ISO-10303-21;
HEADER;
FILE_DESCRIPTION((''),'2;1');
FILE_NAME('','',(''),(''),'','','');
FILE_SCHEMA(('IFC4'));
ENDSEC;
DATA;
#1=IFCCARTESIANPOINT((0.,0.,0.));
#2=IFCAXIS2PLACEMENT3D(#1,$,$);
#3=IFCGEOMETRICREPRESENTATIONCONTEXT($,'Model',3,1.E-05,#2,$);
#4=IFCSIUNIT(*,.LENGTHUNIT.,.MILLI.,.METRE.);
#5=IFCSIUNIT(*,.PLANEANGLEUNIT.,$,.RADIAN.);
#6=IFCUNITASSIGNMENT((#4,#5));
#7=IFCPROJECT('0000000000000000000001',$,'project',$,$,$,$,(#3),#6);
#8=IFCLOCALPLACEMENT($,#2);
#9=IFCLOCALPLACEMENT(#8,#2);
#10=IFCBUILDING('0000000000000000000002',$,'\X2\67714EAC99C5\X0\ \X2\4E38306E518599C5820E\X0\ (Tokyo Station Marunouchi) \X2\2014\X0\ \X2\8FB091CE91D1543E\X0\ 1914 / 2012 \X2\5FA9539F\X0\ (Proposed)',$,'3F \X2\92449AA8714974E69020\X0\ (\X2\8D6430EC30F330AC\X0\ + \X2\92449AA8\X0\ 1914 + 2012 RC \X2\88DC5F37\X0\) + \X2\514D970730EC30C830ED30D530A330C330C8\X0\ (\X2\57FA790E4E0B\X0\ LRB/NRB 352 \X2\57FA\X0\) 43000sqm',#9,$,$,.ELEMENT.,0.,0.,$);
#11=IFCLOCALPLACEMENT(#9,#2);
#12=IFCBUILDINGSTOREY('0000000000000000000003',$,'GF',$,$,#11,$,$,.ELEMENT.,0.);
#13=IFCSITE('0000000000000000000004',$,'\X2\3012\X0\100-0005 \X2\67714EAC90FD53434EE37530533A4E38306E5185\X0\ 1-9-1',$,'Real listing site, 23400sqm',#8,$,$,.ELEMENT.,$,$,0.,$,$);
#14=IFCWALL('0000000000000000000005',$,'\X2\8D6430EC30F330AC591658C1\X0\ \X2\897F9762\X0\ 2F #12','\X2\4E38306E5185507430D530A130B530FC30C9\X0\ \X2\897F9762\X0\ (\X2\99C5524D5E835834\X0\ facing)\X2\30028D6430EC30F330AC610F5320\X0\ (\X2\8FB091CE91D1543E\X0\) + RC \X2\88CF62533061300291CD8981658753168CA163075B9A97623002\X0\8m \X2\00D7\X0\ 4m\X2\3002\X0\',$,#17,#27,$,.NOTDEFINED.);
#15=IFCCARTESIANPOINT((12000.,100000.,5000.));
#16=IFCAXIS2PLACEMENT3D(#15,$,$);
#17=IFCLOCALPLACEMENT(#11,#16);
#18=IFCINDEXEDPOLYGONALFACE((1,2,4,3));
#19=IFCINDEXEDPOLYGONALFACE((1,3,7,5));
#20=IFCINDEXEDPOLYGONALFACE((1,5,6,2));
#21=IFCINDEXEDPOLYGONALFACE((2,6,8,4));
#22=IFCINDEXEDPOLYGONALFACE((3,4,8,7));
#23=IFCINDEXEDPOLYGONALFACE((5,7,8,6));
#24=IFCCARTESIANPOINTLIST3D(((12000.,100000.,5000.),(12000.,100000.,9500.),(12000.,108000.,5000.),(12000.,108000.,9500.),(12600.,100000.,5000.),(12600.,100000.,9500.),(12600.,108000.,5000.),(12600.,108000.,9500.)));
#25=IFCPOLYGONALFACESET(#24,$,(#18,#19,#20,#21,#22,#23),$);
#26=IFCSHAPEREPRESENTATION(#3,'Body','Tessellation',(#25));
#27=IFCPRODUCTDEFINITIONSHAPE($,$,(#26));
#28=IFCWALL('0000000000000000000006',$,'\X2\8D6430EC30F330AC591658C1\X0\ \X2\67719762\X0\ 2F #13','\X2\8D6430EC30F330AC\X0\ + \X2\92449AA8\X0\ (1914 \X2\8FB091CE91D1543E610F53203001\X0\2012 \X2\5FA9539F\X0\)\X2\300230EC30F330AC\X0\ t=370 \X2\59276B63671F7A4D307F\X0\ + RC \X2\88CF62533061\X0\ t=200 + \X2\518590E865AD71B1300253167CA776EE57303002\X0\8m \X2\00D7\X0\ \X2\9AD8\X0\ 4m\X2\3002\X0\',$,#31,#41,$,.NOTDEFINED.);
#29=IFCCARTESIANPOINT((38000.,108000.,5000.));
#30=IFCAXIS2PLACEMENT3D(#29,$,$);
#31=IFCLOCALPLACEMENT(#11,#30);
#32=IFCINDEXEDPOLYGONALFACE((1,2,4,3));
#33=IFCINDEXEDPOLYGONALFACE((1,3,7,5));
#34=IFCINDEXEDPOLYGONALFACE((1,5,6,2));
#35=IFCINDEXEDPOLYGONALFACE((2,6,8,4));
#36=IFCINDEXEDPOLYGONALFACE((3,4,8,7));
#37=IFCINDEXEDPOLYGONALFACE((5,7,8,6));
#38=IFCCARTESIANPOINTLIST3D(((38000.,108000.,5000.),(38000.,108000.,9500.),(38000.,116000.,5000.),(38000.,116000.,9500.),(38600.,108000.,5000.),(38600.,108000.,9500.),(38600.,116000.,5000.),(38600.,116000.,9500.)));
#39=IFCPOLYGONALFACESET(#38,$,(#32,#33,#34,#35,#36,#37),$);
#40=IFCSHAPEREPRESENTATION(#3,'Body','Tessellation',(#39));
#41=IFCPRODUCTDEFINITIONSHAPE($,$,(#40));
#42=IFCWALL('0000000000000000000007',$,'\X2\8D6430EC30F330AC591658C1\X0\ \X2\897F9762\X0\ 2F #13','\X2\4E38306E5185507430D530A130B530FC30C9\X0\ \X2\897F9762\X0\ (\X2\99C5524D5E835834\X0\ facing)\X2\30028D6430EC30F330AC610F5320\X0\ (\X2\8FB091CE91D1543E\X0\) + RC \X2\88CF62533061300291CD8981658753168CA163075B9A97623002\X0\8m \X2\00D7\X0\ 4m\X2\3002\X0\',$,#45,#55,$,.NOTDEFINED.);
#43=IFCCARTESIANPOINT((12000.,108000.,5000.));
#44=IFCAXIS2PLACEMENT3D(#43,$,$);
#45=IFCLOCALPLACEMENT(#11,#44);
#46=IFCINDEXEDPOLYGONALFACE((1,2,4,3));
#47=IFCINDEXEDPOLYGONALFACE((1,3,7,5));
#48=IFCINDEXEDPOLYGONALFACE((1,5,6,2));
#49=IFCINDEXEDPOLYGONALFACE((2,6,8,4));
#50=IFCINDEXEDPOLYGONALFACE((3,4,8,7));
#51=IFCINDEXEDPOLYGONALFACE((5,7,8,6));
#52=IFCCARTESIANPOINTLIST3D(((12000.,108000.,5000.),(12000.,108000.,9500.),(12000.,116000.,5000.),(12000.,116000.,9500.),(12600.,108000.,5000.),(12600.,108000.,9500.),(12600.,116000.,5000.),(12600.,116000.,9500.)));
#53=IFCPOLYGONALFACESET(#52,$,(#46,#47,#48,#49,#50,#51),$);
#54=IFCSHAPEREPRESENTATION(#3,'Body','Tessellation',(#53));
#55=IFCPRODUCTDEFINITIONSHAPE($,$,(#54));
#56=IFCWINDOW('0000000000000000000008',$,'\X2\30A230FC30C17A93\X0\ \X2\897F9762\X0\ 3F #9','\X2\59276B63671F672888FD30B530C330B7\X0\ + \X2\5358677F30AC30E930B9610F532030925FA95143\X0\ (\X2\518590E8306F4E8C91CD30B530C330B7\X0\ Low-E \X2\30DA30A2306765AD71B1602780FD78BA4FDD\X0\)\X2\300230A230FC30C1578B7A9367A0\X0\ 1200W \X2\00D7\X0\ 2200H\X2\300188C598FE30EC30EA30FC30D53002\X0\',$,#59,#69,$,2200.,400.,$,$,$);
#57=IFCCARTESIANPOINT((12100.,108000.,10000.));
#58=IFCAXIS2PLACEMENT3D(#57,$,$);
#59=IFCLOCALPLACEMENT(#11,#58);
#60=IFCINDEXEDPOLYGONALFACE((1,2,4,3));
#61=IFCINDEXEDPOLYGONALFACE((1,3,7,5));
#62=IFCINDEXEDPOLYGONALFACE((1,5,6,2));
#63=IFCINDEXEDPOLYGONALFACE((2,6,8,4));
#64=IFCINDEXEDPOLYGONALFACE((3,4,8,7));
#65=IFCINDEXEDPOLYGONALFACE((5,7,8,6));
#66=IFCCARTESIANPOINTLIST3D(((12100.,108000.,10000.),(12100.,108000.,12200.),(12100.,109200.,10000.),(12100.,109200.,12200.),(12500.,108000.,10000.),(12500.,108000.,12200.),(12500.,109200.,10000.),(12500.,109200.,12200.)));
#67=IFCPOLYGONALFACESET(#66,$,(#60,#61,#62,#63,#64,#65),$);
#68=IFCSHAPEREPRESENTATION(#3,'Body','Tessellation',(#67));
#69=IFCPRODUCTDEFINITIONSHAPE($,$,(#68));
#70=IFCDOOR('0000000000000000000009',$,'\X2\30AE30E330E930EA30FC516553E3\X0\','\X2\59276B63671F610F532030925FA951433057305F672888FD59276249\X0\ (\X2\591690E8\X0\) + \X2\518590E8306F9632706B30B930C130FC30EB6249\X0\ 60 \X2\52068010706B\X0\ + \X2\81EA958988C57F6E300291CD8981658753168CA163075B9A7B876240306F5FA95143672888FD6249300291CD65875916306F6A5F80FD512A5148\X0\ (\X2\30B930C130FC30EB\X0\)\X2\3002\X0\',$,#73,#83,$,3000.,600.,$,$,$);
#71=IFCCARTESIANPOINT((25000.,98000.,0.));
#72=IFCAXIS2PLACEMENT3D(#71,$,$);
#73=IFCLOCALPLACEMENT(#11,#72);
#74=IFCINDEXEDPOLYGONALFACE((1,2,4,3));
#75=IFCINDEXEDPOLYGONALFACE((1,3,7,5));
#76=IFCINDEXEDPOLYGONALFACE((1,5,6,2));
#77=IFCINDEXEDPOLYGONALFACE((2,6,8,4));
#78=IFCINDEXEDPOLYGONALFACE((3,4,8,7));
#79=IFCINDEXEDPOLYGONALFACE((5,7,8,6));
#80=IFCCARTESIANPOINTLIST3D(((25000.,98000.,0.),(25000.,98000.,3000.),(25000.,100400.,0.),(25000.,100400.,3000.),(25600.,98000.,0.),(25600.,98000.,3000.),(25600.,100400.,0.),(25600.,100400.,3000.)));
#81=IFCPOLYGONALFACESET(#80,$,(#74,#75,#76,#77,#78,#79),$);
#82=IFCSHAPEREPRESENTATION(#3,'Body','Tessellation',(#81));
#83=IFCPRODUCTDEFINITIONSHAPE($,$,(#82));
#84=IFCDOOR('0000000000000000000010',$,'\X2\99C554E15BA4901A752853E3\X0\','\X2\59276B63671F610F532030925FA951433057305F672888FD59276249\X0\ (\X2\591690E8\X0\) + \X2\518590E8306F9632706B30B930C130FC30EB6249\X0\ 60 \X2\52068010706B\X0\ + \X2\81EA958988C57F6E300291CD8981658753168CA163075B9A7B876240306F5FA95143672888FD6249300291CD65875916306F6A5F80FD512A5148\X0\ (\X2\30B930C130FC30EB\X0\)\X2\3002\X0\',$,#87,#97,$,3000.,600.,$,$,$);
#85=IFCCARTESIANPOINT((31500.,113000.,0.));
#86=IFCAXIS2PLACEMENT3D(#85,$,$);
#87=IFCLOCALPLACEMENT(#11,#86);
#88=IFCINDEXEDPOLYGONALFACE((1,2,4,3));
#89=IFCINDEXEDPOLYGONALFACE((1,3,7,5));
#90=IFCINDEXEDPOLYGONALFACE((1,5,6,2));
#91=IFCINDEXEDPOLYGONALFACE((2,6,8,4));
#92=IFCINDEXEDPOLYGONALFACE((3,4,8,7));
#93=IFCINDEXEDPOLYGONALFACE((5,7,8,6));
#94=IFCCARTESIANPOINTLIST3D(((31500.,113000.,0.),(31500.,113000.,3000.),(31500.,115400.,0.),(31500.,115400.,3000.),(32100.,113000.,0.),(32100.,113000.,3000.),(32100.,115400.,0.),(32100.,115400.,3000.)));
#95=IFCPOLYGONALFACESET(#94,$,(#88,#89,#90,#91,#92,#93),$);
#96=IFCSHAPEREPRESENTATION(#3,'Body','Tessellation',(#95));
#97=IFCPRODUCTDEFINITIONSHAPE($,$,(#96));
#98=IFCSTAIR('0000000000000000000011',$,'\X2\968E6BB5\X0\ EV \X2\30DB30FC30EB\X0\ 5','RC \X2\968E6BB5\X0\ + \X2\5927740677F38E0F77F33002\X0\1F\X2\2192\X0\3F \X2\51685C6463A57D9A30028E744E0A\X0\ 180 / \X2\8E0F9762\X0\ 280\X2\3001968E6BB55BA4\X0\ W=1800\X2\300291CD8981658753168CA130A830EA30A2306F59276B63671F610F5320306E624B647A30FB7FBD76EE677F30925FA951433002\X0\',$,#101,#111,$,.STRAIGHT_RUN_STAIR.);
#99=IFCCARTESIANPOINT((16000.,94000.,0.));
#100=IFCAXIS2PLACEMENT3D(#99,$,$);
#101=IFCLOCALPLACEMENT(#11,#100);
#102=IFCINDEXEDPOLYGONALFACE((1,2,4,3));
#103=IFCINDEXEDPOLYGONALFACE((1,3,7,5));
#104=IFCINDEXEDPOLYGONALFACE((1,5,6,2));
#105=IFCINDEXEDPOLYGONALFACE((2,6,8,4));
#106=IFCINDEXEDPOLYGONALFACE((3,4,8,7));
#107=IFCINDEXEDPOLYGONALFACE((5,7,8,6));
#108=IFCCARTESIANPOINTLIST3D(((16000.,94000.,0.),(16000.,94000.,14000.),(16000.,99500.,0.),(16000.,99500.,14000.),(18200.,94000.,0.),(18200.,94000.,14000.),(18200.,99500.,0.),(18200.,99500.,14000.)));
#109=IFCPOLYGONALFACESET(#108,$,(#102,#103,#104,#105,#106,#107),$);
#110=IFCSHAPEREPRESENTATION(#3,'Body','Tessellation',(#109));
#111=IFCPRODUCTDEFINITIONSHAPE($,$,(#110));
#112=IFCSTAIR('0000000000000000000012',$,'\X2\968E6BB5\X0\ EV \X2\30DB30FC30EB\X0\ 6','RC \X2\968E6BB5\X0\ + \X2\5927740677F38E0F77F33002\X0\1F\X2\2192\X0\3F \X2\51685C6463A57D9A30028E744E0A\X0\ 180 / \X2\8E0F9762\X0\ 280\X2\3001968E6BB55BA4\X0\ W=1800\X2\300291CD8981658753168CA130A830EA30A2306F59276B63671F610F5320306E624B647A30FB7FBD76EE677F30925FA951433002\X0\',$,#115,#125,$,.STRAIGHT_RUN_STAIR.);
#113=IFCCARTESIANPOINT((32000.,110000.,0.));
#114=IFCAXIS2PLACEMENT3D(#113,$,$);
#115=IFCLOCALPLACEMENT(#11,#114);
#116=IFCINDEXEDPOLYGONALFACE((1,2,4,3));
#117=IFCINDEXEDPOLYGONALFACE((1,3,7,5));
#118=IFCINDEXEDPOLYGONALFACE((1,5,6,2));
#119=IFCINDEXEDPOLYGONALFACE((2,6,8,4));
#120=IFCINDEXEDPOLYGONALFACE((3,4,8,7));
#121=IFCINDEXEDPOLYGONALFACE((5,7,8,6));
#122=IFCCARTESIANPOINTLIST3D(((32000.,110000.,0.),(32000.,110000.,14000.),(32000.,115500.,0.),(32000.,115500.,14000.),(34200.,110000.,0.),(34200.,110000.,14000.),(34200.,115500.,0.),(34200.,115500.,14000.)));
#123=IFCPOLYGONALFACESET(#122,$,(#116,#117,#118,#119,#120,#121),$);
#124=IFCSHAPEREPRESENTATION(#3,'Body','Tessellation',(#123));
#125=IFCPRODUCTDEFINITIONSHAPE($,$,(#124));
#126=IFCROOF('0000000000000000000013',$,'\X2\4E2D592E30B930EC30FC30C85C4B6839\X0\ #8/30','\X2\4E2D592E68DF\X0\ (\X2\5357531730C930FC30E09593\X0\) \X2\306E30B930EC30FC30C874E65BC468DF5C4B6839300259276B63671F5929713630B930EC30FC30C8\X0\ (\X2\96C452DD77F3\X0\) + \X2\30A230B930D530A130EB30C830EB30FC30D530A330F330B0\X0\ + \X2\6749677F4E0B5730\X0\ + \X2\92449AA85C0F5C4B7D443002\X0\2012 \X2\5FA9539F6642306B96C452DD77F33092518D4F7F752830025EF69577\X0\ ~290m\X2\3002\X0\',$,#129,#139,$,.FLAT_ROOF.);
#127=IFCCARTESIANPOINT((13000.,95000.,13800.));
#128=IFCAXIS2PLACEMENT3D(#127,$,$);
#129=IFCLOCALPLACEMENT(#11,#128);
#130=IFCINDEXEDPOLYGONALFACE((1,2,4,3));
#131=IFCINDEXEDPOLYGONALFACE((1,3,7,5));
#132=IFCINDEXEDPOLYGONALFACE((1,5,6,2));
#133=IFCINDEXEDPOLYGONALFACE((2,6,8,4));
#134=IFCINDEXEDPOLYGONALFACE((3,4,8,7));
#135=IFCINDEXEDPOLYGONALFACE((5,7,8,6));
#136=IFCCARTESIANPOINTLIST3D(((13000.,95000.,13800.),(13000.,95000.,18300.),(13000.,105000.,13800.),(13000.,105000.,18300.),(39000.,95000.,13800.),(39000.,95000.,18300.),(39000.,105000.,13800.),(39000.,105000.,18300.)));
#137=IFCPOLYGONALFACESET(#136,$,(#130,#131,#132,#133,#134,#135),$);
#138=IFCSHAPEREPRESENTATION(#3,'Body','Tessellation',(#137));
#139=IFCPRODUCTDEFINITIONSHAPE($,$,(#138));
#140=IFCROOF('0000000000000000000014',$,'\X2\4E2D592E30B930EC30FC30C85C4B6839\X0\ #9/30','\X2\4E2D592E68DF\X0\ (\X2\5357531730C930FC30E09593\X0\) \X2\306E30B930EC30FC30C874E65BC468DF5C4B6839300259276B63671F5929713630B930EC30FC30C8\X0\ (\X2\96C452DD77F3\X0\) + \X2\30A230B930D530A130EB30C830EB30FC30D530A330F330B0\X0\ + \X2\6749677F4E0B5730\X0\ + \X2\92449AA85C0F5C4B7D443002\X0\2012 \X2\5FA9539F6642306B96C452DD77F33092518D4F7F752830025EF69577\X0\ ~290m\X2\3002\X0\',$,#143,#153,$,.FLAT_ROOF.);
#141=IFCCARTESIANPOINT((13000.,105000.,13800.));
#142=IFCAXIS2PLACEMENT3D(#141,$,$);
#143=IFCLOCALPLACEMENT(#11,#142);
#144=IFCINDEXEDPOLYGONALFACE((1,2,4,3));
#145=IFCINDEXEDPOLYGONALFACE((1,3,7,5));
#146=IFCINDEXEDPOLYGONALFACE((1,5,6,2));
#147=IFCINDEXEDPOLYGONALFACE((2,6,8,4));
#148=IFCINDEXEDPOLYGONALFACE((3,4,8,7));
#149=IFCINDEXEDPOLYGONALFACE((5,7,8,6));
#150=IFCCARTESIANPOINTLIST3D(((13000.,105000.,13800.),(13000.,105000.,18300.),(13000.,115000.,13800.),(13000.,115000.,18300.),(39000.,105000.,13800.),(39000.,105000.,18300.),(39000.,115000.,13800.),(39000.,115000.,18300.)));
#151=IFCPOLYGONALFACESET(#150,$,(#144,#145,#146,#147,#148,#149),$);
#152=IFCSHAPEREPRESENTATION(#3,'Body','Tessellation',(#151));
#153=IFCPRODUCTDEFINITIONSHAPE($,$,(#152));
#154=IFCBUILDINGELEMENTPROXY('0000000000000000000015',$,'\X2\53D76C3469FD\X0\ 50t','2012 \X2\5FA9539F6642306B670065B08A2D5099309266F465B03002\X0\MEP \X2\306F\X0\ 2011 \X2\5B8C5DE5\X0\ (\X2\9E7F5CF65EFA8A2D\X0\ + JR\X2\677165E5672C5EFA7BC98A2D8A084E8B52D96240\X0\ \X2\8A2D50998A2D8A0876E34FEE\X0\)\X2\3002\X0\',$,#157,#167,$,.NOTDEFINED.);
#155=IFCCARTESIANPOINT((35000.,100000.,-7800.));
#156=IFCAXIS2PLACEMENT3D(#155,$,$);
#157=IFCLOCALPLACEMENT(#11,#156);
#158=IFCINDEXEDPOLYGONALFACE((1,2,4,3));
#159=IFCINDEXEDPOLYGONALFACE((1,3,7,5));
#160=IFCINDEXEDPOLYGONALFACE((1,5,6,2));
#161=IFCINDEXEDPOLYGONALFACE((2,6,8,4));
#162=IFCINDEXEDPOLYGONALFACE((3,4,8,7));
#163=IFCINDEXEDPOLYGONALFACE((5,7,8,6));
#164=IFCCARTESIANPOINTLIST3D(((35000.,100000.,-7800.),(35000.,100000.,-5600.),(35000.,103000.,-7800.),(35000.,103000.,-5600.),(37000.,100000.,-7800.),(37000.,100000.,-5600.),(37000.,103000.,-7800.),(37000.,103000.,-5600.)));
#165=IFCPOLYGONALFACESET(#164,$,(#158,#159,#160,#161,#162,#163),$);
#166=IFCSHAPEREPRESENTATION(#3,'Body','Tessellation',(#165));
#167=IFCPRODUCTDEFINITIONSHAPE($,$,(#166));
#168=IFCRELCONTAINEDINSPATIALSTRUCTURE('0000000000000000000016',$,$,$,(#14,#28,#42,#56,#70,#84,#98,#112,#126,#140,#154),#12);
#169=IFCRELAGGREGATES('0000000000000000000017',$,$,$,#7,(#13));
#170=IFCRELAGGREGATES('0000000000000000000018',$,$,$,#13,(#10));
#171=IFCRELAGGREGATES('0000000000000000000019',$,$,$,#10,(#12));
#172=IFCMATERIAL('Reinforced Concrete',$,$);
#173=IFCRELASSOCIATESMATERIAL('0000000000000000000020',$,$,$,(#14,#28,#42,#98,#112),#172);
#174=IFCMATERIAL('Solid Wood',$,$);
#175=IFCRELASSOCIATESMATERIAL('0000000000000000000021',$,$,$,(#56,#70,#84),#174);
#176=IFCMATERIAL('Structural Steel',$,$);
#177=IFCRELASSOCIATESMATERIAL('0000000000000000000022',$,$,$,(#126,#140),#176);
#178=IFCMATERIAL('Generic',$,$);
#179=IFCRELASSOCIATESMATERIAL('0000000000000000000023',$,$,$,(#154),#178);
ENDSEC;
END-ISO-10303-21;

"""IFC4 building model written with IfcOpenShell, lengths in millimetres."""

from ifc_helpers import new_model, si_unit, frame, frame_2d, origin, place, context, project, spatial, rectangle, extrude, material, element, save


model = new_model("IFC4")

# Units and contexts
model_context = context("Model", 3, precision=1e-05, world=origin())
ifc_project = project(units=[si_unit("LENGTHUNIT", "METRE", prefix="MILLI"), si_unit("PLANEANGLEUNIT", "RADIAN")], contexts=[model_context])

# Site, building, storey
site_placement = place(None, origin())
site = spatial("IfcSite", under=ifc_project, at=site_placement, Name="〒100-0005 東京都千代田区丸の内 1-9-1", ObjectType="Real listing site, 23400sqm", CompositionType="ELEMENT", RefElevation=0.0)
building_placement = place(site_placement, origin())
building = spatial("IfcBuilding", under=site, at=building_placement, Name="東京駅 丸の内駅舎 (Tokyo Station Marunouchi) — 辰野金吾 1914 / 2012 復原 (Proposed)", ObjectType="3F 鉄骨煉瓦造 (赤レンガ + 鉄骨 1914 + 2012 RC 補強) + 免震レトロフィット (基礎下 LRB/NRB 352 基) 43000sqm", CompositionType="ELEMENT", ElevationOfRefHeight=0.0, ElevationOfTerrain=0.0)
storey_placement = place(building_placement, origin())
storey = spatial("IfcBuildingStorey", under=building, at=storey_placement, Name="GF", CompositionType="ELEMENT", Elevation=0.0)

# Shared definitions
ifc_material_1 = material(Name="Structural Steel")

# Shared definitions
ifc_material_2 = material(Name="Reinforced Concrete")
ifc_material_3 = material(Name="Generic")

# Shared definitions
ifc_material_4 = material(Name="Solid Wood")

# Walls
wall_1_placement = place(storey_placement, frame((12000.0, 100000.0, 5000.0)))
element("IfcWall", 1, at=wall_1_placement, inside=storey, material=ifc_material_2, Name="赤レンガ外壁 西面 2F #12", Description="丸の内側ファサード 西面 (駅前広場 facing)。赤レンガ意匠 (辰野金吾) + RC 裏打ち。重要文化財指定面。8m × 4m。", PredefinedType="NOTDEFINED", context=model_context, shape_type="SweptSolid", body=[
    extrude(rectangle(XDim=600.0, YDim=8000.0, at=frame_2d((300.0, 4000.0))), frame((12000.0, 100000.0, 5000.0)), (0.0, 0.0, 1.0), 4500.0),
])
wall_2_placement = place(storey_placement, frame((38000.0, 108000.0, 5000.0)))
element("IfcWall", 2, at=wall_2_placement, inside=storey, material=ifc_material_2, Name="赤レンガ外壁 東面 2F #13", Description="赤レンガ + 鉄骨 (1914 辰野金吾意匠、2012 復原)。レンガ t=370 大正期積み + RC 裏打ち t=200 + 内部断熱。化粧目地。8m × 高 4m。", PredefinedType="NOTDEFINED", context=model_context, shape_type="SweptSolid", body=[
    extrude(rectangle(XDim=600.0, YDim=8000.0, at=frame_2d((300.0, 4000.0))), frame((38000.0, 108000.0, 5000.0)), (0.0, 0.0, 1.0), 4500.0),
])
wall_3_placement = place(storey_placement, frame((12000.0, 108000.0, 5000.0)))
element("IfcWall", 3, at=wall_3_placement, inside=storey, material=ifc_material_2, Name="赤レンガ外壁 西面 2F #13", Description="丸の内側ファサード 西面 (駅前広場 facing)。赤レンガ意匠 (辰野金吾) + RC 裏打ち。重要文化財指定面。8m × 4m。", PredefinedType="NOTDEFINED", context=model_context, shape_type="SweptSolid", body=[
    extrude(rectangle(XDim=600.0, YDim=8000.0, at=frame_2d((300.0, 4000.0))), frame((12000.0, 108000.0, 5000.0)), (0.0, 0.0, 1.0), 4500.0),
])

# Window
window_1_placement = place(storey_placement, frame((12100.0, 108000.0, 10000.0)))
element("IfcWindow", 4, at=window_1_placement, inside=storey, material=ifc_material_4, Name="アーチ窓 西面 3F #9", Description="大正期木製サッシ + 単板ガラス意匠を復元 (内部は二重サッシ Low-E ペアで断熱性能確保)。アーチ型窓枠 1200W × 2200H、装飾レリーフ。", OverallHeight=2200.0, OverallWidth=400.0, context=model_context, shape_type="SweptSolid", body=[
    extrude(rectangle(XDim=400.0, YDim=1200.0, at=frame_2d((200.0, 600.0))), frame((12100.0, 108000.0, 10000.0)), (0.0, 0.0, 1.0), 2200.0),
])

# Doors
door_1_placement = place(storey_placement, frame((25000.0, 98000.0, 0.0)))
element("IfcDoor", 5, at=door_1_placement, inside=storey, material=ifc_material_4, Name="ギャラリー入口", Description="大正期意匠を復元した木製大扉 (外部) + 内部は防火スチール扉 60 分耐火 + 自閉装置。重要文化財指定箇所は復元木製扉。重文外は機能優先 (スチール)。", OverallHeight=3000.0, OverallWidth=600.0, context=model_context, shape_type="SweptSolid", body=[
    extrude(rectangle(XDim=600.0, YDim=2400.0, at=frame_2d((300.0, 1200.0))), frame((25000.0, 98000.0, 0.0)), (0.0, 0.0, 1.0), 3000.0),
])
door_2_placement = place(storey_placement, frame((31500.0, 113000.0, 0.0)))
element("IfcDoor", 6, at=door_2_placement, inside=storey, material=ifc_material_4, Name="駅員室通用口", Description="大正期意匠を復元した木製大扉 (外部) + 内部は防火スチール扉 60 分耐火 + 自閉装置。重要文化財指定箇所は復元木製扉。重文外は機能優先 (スチール)。", OverallHeight=3000.0, OverallWidth=600.0, context=model_context, shape_type="SweptSolid", body=[
    extrude(rectangle(XDim=600.0, YDim=2400.0, at=frame_2d((300.0, 1200.0))), frame((31500.0, 113000.0, 0.0)), (0.0, 0.0, 1.0), 3000.0),
])

# Stairs
stair_1_placement = place(storey_placement, frame((16000.0, 94000.0, 0.0)))
element("IfcStair", 7, at=stair_1_placement, inside=storey, material=ifc_material_2, Name="階段 EV ホール 5", Description="RC 階段 + 大理石踏石。1F→3F 全層接続。蹴上 180 / 踏面 280、階段室 W=1800。重要文化財エリアは大正期意匠の手摺・羽目板を復元。", PredefinedType="STRAIGHT_RUN_STAIR", context=model_context, shape_type="SweptSolid", body=[
    extrude(rectangle(XDim=2200.0, YDim=5500.0, at=frame_2d((1100.0, 2750.0))), frame((16000.0, 94000.0, 0.0)), (0.0, 0.0, 1.0), 14000.0),
])
stair_2_placement = place(storey_placement, frame((32000.0, 110000.0, 0.0)))
element("IfcStair", 8, at=stair_2_placement, inside=storey, material=ifc_material_2, Name="階段 EV ホール 6", Description="RC 階段 + 大理石踏石。1F→3F 全層接続。蹴上 180 / 踏面 280、階段室 W=1800。重要文化財エリアは大正期意匠の手摺・羽目板を復元。", PredefinedType="STRAIGHT_RUN_STAIR", context=model_context, shape_type="SweptSolid", body=[
    extrude(rectangle(XDim=2200.0, YDim=5500.0, at=frame_2d((1100.0, 2750.0))), frame((32000.0, 110000.0, 0.0)), (0.0, 0.0, 1.0), 14000.0),
])

# Roofs
roof_1_placement = place(storey_placement, frame((13000.0, 95000.0, 13800.0)))
element("IfcRoof", 9, at=roof_1_placement, inside=storey, material=ifc_material_1, Name="中央スレート屋根 #8/30", Description="中央棟 (南北ドーム間) のスレート瓦寄棟屋根。大正期天然スレート (雄勝石) + アスファルトルーフィング + 杉板下地 + 鉄骨小屋組。2012 復原時に雄勝石を再使用。延長 ~290m。", PredefinedType="FLAT_ROOF", context=model_context, shape_type="SweptSolid", body=[
    extrude(rectangle(XDim=26000.0, YDim=10000.0, at=frame_2d((13000.0, 5000.0))), frame((13000.0, 95000.0, 13800.0)), (0.0, 0.0, 1.0), 4500.0),
])
roof_2_placement = place(storey_placement, frame((13000.0, 105000.0, 13800.0)))
element("IfcRoof", 10, at=roof_2_placement, inside=storey, material=ifc_material_1, Name="中央スレート屋根 #9/30", Description="中央棟 (南北ドーム間) のスレート瓦寄棟屋根。大正期天然スレート (雄勝石) + アスファルトルーフィング + 杉板下地 + 鉄骨小屋組。2012 復原時に雄勝石を再使用。延長 ~290m。", PredefinedType="FLAT_ROOF", context=model_context, shape_type="SweptSolid", body=[
    extrude(rectangle(XDim=26000.0, YDim=10000.0, at=frame_2d((13000.0, 5000.0))), frame((13000.0, 105000.0, 13800.0)), (0.0, 0.0, 1.0), 4500.0),
])

# Building element proxy
proxy_placement = place(storey_placement, frame((35000.0, 100000.0, -7800.0)))
element("IfcBuildingElementProxy", 11, at=proxy_placement, inside=storey, material=ifc_material_3, Name="受水槽 50t", Description="2012 復原時に最新設備を更新。MEP は 2011 完工 (鹿島建設 + JR東日本建築設計事務所 設備設計監修)。", PredefinedType="NOTDEFINED", context=model_context, shape_type="SweptSolid", body=[
    extrude(rectangle(XDim=2000.0, YDim=3000.0, at=frame_2d((1000.0, 1500.0))), frame((35000.0, 100000.0, -7800.0)), (0.0, 0.0, 1.0), 2200.0),
])

save(model, "model.ifc")
